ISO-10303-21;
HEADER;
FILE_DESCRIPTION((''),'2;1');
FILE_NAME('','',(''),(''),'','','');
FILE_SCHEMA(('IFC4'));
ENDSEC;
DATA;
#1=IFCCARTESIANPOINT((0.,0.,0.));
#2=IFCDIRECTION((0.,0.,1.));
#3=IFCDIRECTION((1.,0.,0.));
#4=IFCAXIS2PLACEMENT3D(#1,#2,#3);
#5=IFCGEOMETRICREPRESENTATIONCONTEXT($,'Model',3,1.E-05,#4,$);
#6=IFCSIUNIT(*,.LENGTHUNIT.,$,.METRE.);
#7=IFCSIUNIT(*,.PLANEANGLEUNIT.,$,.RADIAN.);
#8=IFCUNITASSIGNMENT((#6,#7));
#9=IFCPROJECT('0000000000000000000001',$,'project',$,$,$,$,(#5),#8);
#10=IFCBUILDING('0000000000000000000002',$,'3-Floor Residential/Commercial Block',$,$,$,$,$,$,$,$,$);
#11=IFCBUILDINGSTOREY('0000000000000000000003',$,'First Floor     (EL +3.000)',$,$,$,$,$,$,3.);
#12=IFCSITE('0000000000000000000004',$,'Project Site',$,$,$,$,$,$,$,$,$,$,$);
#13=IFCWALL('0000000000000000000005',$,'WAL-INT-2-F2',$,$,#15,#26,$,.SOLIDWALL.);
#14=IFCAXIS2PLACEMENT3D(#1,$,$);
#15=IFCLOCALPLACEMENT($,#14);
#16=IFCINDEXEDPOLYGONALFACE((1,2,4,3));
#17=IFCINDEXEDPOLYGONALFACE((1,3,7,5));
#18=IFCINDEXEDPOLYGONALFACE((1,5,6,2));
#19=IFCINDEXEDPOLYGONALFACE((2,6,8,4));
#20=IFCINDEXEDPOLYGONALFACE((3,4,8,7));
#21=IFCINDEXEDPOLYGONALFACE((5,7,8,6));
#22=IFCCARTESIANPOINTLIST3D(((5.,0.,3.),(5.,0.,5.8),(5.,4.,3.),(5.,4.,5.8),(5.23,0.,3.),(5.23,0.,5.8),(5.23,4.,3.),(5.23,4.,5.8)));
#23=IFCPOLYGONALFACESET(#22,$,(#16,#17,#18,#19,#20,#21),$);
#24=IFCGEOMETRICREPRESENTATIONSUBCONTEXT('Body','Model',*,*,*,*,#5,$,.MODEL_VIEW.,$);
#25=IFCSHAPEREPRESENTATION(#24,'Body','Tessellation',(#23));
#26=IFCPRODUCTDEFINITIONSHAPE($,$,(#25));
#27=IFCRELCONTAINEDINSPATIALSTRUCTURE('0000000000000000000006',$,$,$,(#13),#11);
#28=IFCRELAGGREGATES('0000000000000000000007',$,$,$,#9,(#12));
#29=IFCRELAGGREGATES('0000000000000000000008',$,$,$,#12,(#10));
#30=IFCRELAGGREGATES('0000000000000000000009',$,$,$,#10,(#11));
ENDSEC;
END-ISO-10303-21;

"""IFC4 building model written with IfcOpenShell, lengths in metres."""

from ifc_helpers import new_model, si_unit, frame, frame_2d, origin_with_axes, place, context, subcontext, project, spatial, rectangle, extrude, element, save


model = new_model("IFC4")

# Units and contexts
model_context = context("Model", 3, precision=1e-05, world=origin_with_axes())
body_context = subcontext(model_context, "Body", "Model", "MODEL_VIEW")
ifc_project = project(units=[si_unit("LENGTHUNIT", "METRE"), si_unit("PLANEANGLEUNIT", "RADIAN")], contexts=[model_context])

# Site, building, storey
site = spatial("IfcSite", under=ifc_project, Name="Project Site")
building = spatial("IfcBuilding", under=site, Name="3-Floor Residential/Commercial Block")
storey = spatial("IfcBuildingStorey", under=building, Name="First Floor     (EL +3.000)", Elevation=3.0)

# Wall
wall_1_placement = place(None, frame((5.0, 0.0, 3.0), z_axis=(0.0, 0.0, 1.0), x_axis=(1.0, 0.0, 0.0)))
element("IfcWall", 1, at=wall_1_placement, inside=storey, Name="WAL-INT-2-F2", PredefinedType="SOLIDWALL", context=body_context, shape_type="SweptSolid", body=[
    extrude(rectangle(XDim=0.23, YDim=4.0, at=frame_2d((0.115, 2.0))), origin_with_axes(), (0.0, 0.0, 1.0), 2.8),
])

save(model, "model.ifc")
